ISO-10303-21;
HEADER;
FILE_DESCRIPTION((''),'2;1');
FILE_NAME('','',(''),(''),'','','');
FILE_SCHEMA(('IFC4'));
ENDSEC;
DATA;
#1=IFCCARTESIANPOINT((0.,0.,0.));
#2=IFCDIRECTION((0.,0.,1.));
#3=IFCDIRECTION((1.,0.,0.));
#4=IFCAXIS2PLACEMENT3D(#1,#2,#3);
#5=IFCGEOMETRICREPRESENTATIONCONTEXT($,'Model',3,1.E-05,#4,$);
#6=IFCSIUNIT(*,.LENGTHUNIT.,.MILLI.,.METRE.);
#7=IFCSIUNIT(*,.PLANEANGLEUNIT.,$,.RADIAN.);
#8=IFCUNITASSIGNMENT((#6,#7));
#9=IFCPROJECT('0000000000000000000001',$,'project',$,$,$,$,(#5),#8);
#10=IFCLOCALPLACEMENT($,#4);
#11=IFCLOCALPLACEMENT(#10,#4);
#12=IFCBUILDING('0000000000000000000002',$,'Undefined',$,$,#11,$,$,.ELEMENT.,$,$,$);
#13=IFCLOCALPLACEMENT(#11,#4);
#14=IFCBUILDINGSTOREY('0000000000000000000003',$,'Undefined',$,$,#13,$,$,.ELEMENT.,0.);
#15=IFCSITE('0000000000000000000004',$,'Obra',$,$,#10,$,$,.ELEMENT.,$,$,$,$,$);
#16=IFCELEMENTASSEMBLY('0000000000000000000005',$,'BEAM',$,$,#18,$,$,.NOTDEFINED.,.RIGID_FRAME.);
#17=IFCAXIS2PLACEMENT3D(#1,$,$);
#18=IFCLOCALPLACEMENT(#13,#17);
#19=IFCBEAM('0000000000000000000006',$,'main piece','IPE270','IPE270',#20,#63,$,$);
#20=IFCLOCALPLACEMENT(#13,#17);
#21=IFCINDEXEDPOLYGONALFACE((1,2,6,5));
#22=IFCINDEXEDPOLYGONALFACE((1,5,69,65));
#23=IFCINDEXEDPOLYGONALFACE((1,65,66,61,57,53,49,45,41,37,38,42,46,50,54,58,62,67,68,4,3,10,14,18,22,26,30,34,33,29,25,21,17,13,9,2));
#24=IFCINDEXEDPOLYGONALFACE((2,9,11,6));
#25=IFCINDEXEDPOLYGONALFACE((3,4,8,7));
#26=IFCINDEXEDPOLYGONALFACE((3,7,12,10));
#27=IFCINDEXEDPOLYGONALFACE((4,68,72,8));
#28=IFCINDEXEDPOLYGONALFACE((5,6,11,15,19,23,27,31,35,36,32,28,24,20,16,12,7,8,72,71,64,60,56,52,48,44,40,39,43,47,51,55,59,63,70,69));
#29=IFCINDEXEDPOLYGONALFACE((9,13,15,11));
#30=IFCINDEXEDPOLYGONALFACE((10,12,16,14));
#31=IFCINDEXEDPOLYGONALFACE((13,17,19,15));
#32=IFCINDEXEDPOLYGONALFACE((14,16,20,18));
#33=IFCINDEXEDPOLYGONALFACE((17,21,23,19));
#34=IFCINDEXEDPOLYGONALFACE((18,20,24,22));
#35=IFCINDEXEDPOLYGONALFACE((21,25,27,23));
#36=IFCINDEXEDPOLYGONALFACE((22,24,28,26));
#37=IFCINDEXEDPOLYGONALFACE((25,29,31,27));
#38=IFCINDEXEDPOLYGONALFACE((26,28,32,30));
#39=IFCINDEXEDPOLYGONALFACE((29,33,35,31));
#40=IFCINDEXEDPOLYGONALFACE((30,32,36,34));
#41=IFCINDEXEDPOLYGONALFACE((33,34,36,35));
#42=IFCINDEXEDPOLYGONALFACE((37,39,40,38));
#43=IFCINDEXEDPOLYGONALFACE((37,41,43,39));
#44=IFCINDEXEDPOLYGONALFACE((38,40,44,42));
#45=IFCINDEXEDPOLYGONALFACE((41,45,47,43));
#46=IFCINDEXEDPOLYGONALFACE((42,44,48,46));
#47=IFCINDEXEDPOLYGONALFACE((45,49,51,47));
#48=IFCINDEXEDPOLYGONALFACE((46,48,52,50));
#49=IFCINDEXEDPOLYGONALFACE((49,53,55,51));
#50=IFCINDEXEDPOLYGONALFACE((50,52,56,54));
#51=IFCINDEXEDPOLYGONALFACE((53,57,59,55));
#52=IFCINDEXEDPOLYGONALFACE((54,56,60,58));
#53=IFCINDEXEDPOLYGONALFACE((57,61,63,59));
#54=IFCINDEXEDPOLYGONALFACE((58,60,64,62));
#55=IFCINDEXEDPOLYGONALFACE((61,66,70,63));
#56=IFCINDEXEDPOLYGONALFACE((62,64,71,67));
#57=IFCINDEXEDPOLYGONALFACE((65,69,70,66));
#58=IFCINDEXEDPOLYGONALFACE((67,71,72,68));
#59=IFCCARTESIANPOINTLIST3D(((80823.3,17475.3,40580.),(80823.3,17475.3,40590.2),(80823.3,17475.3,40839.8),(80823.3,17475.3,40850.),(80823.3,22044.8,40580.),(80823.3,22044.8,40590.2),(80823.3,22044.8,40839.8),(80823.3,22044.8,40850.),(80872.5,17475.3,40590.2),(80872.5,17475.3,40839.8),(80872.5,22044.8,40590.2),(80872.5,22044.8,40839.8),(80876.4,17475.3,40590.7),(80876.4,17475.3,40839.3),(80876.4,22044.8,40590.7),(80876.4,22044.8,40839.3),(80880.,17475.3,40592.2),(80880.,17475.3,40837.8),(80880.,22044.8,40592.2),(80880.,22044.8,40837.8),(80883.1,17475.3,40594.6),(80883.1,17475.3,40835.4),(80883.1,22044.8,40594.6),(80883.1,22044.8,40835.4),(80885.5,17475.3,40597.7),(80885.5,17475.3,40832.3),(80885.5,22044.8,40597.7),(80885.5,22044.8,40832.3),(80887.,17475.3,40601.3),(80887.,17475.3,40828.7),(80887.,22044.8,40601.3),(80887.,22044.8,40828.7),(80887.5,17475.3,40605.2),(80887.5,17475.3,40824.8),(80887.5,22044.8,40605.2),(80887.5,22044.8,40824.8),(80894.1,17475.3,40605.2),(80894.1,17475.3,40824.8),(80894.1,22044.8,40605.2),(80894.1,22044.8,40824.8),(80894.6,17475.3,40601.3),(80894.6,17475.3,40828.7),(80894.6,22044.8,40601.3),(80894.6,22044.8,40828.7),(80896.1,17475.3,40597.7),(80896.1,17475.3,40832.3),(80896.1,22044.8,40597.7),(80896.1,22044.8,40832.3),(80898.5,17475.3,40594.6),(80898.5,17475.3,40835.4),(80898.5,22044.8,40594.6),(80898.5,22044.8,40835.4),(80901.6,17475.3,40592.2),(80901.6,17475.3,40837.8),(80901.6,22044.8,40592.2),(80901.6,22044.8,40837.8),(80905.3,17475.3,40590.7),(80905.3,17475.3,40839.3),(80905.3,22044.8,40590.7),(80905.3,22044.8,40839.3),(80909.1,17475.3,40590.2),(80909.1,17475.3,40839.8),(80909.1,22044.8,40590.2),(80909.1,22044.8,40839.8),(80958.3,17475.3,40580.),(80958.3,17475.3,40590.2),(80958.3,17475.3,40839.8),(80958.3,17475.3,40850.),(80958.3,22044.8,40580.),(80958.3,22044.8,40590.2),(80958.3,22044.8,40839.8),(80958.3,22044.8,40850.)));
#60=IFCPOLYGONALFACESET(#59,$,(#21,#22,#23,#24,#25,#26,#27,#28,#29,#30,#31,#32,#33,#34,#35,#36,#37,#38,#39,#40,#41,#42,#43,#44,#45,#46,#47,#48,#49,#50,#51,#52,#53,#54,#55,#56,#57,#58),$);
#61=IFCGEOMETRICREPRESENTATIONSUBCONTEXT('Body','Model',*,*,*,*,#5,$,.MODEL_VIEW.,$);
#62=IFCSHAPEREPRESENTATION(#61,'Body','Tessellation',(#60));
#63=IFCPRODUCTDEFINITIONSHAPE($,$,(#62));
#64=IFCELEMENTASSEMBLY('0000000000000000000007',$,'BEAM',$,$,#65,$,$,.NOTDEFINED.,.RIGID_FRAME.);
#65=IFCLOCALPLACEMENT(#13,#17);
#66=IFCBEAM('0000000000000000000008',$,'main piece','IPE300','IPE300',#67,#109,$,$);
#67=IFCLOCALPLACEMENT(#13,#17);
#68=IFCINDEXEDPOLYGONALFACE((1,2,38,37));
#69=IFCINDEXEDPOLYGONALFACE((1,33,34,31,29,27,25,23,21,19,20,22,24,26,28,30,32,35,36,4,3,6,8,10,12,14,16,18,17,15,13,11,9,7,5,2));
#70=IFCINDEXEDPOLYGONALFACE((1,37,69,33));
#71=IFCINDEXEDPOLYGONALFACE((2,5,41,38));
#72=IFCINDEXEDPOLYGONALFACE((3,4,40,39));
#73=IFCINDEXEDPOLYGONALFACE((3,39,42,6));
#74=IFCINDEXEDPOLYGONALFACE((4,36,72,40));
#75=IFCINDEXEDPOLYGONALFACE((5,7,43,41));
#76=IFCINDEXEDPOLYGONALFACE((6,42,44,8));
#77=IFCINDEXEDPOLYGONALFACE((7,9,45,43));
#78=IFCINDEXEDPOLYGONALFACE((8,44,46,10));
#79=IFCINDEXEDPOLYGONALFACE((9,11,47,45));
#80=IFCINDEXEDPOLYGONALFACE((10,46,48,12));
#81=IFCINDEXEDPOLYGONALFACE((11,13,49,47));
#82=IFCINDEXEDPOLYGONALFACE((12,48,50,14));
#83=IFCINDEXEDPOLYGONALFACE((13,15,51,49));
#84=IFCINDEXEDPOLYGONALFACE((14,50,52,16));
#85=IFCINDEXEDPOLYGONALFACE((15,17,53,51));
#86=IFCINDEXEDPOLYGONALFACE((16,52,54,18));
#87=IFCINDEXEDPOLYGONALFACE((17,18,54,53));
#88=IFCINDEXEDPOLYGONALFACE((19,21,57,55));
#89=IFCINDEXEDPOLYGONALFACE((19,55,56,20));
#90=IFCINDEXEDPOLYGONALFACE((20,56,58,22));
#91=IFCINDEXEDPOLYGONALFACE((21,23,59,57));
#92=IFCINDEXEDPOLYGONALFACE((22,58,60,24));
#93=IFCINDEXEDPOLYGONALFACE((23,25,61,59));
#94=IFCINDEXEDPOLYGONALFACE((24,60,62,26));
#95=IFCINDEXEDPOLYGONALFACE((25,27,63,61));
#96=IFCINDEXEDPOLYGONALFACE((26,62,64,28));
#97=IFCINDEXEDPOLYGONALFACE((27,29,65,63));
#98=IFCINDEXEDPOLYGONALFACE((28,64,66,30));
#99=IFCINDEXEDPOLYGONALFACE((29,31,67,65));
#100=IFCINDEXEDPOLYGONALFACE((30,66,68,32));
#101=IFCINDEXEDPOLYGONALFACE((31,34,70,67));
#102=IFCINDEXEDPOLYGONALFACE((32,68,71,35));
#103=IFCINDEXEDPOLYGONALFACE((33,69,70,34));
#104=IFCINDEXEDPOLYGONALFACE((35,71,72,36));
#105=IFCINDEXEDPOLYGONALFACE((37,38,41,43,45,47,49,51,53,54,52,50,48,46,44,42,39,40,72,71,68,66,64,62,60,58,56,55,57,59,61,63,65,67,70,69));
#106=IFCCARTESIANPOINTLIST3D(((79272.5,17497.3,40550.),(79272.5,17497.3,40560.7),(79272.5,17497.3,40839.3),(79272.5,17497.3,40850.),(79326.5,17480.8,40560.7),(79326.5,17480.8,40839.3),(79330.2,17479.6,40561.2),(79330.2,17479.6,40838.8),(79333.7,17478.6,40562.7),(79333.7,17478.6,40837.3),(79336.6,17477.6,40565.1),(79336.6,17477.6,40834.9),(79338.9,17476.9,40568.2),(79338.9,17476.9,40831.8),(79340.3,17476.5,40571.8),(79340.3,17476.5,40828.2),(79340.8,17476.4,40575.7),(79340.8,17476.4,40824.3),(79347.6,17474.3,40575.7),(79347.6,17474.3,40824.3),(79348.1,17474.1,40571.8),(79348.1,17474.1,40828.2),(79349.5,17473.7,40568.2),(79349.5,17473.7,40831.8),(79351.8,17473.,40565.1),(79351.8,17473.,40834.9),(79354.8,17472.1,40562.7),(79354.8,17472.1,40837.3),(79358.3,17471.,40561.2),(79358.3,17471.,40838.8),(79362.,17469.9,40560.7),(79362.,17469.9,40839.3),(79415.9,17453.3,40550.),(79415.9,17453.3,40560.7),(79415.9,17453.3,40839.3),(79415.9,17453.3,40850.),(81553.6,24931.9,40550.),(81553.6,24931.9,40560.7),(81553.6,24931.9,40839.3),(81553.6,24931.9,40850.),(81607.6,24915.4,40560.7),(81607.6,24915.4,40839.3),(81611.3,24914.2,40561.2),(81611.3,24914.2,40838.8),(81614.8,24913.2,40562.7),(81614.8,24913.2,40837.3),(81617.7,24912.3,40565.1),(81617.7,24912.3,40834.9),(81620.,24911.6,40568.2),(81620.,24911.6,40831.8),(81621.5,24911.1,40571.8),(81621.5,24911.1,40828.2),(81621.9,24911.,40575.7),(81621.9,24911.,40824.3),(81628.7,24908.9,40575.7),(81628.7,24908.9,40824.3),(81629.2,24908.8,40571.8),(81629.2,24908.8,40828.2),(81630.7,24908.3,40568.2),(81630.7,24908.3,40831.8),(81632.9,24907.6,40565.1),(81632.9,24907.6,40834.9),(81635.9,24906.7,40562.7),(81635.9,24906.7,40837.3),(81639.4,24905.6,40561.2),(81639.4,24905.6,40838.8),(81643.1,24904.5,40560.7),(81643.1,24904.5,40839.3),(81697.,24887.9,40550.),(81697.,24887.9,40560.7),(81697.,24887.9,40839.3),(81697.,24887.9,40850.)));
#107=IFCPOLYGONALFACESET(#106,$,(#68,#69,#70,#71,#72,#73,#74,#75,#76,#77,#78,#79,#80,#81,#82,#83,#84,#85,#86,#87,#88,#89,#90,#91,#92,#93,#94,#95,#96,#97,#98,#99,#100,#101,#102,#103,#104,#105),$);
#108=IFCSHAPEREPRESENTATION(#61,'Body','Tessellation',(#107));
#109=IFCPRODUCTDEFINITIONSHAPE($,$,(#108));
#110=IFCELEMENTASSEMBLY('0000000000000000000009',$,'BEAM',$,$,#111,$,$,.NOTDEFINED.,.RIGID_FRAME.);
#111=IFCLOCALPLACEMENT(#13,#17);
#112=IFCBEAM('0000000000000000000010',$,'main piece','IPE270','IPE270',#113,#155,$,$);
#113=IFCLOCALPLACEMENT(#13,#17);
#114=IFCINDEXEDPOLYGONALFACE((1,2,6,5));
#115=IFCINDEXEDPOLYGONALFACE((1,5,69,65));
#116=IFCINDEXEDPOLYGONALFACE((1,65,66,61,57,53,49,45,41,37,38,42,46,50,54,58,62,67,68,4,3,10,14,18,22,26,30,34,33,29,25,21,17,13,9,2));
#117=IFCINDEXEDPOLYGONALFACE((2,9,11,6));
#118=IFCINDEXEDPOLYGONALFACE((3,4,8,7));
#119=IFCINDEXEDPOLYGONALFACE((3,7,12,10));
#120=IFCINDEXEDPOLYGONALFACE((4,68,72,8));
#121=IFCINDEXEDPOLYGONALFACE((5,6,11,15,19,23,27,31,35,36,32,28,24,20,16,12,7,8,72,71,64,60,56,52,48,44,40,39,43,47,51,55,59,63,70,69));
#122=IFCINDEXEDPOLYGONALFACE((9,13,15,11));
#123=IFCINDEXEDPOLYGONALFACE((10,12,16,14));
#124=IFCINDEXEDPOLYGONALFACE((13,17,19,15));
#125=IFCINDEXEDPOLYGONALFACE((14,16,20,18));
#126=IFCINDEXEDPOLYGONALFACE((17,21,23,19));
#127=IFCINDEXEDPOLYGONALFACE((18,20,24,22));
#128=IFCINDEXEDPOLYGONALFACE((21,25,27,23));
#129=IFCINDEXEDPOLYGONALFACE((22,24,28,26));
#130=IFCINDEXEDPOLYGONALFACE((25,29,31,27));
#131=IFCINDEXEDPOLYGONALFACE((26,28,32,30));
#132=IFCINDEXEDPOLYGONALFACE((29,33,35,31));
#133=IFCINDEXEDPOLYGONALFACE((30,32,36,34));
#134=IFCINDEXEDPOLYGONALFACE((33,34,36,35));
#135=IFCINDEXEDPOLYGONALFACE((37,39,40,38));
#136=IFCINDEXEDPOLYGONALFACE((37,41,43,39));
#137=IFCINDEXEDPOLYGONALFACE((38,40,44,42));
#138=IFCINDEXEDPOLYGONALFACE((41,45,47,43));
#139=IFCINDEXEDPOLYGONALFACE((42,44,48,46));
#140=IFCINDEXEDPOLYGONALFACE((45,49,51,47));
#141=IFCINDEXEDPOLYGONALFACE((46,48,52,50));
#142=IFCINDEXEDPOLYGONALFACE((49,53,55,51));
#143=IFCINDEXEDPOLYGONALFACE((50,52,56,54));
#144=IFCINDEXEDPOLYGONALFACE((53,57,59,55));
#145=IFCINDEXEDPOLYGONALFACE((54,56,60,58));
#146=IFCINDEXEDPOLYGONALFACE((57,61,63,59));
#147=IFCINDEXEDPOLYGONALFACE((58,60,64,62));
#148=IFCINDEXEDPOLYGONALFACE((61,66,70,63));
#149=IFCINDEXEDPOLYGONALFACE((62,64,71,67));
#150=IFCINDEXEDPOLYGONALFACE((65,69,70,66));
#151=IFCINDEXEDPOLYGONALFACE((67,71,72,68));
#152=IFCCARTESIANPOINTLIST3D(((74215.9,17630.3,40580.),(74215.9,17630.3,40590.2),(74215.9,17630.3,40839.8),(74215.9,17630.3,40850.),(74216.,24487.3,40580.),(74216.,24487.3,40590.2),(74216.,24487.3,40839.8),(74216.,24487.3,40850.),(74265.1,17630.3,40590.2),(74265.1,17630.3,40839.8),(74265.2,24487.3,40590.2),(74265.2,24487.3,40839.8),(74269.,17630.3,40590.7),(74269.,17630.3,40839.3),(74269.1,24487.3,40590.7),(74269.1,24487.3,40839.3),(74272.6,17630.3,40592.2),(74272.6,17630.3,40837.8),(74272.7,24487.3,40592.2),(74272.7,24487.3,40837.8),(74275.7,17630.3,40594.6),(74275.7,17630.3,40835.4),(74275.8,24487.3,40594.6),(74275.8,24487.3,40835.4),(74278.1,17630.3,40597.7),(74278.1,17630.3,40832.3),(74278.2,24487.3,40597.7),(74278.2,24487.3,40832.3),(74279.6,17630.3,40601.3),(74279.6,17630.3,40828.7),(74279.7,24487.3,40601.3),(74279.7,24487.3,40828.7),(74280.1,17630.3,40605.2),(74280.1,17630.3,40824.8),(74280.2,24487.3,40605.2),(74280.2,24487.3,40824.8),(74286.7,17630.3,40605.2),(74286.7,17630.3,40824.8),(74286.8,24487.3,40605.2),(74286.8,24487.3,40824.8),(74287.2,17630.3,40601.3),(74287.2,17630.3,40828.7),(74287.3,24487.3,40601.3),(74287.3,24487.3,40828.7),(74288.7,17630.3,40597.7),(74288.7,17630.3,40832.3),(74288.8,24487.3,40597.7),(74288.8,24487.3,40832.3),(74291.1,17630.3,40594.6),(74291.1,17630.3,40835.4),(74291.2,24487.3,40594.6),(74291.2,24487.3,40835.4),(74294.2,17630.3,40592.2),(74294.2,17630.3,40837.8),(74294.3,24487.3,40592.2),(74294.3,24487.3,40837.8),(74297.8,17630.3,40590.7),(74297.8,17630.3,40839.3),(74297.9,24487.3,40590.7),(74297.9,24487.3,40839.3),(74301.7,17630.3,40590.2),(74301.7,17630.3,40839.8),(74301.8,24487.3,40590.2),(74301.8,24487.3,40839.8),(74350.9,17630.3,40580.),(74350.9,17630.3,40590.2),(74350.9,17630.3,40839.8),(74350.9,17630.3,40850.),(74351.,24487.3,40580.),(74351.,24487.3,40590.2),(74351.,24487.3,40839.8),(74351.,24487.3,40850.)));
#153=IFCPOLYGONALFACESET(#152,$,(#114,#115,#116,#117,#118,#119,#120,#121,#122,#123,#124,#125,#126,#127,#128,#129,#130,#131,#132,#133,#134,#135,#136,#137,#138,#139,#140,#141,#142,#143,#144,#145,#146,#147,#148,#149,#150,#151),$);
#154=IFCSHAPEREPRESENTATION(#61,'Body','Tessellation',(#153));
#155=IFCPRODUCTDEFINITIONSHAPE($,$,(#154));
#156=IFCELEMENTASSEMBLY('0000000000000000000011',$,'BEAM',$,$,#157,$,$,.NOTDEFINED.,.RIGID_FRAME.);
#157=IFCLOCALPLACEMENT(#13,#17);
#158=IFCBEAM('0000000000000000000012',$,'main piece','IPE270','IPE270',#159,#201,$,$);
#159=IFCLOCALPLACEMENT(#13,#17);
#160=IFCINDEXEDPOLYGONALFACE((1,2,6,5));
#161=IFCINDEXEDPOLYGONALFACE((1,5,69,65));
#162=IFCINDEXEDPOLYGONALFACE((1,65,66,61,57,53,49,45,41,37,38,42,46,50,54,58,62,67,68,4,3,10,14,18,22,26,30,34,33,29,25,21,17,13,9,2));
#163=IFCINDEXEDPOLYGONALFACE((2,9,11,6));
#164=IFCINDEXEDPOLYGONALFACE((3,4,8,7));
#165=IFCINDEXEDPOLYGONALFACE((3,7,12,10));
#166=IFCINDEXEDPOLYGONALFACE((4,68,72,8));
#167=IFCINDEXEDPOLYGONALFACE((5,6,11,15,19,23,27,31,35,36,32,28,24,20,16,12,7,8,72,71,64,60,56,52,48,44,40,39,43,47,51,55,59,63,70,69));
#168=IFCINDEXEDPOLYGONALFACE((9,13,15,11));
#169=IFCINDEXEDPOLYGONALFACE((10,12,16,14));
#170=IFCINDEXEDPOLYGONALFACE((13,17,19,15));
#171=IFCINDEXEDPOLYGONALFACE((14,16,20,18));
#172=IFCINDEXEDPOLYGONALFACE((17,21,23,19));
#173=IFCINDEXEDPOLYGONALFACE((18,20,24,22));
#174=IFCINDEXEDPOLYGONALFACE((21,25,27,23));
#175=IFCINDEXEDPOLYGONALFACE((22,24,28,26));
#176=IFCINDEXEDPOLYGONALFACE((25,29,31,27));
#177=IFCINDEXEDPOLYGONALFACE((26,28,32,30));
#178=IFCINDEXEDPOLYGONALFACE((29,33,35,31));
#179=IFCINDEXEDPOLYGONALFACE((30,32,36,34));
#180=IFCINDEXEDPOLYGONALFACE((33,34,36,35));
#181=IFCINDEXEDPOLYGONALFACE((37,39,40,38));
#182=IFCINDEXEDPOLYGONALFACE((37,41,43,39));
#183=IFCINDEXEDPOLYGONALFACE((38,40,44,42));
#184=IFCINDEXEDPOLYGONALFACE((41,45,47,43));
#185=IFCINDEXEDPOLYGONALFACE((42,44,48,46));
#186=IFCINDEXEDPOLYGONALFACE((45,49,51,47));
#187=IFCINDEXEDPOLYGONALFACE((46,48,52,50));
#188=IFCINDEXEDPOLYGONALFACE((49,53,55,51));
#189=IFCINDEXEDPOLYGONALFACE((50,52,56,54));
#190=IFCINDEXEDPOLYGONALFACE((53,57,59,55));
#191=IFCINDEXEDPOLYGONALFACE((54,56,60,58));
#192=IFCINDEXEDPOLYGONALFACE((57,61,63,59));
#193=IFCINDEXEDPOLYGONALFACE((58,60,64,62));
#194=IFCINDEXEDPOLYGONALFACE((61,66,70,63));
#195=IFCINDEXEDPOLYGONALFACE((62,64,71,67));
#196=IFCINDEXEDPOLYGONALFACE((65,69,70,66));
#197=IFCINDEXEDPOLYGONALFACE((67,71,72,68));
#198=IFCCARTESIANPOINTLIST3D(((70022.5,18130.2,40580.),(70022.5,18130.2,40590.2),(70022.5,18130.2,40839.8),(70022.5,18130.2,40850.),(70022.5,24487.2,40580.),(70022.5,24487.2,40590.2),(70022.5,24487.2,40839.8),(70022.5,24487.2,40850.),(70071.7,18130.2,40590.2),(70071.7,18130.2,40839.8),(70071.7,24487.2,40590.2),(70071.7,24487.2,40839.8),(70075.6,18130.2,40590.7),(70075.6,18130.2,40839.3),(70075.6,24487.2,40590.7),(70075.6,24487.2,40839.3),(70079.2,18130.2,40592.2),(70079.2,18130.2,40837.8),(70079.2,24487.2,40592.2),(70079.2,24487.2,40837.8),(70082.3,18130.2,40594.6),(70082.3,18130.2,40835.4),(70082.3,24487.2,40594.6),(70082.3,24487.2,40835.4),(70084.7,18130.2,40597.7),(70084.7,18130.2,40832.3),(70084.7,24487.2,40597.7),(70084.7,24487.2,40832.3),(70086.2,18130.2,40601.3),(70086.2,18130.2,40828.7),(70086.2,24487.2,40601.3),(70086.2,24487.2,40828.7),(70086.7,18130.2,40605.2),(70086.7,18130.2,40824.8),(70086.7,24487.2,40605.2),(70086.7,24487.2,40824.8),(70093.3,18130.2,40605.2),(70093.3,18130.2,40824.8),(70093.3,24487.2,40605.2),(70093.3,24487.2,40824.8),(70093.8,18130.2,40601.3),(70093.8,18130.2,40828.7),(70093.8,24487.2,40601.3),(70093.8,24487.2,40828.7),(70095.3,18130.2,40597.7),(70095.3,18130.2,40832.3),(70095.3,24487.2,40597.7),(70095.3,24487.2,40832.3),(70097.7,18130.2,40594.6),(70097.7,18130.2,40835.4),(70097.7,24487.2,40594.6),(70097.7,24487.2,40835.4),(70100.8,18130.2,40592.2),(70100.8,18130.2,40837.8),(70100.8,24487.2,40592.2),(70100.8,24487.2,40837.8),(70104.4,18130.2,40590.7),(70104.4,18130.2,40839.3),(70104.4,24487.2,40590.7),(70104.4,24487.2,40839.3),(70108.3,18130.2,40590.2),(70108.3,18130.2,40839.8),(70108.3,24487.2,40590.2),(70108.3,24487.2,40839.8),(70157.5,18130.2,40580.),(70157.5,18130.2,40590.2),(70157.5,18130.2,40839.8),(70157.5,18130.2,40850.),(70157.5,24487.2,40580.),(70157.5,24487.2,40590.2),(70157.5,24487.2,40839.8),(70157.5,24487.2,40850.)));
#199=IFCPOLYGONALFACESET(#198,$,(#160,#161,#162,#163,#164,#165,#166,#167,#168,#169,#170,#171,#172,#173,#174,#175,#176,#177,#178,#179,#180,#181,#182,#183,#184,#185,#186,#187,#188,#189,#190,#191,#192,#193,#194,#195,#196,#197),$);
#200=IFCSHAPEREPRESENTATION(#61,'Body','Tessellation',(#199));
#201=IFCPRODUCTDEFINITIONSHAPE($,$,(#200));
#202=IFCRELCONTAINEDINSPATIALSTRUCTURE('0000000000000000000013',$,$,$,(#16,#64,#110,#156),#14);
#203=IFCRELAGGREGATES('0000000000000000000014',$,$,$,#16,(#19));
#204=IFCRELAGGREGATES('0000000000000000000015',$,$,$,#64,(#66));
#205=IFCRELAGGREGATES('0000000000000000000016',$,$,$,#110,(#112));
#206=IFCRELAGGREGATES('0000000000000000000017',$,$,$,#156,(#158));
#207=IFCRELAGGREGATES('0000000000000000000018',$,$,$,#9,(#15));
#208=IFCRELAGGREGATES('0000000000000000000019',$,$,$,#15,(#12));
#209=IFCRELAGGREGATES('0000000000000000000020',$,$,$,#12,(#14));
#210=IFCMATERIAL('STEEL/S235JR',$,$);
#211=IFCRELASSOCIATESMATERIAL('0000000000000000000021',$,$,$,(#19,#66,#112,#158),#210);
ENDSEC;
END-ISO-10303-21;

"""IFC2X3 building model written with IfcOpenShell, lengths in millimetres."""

from ifc_helpers import new_model, si_unit, frame, origin_with_axes, origin_2d_with_axis, place, context, subcontext, project, spatial, i_section, extrude, material, element, aggregate, save


model = new_model("IFC2X3")

# Units and contexts
model_context = context("Model", 3, precision=1e-05, world=origin_with_axes())
body_context = subcontext(model_context, "Body", "Model", "MODEL_VIEW")
ifc_project = project(units=[si_unit("LENGTHUNIT", "METRE", prefix="MILLI"), si_unit("PLANEANGLEUNIT", "RADIAN")], contexts=[model_context])

# Site, building, storey
site_placement = place(None, origin_with_axes())
site = spatial("IfcSite", under=ifc_project, at=site_placement, Name="Obra", CompositionType="ELEMENT")
building_placement = place(site_placement, origin_with_axes())
building = spatial("IfcBuilding", under=site, at=building_placement, Name="Undefined", CompositionType="ELEMENT")
storey_placement = place(building_placement, origin_with_axes())
storey = spatial("IfcBuildingStorey", under=building, at=storey_placement, Name="Undefined", CompositionType="ELEMENT", Elevation=0.0)

# Element assemblies, beams
ifc_material_1 = material(Name="STEEL/S235JR")
assembly_1_placement = place(storey_placement, origin_with_axes())
assembly_1 = element("IfcElementAssembly", 1, at=assembly_1_placement, inside=storey, Name="BEAM", AssemblyPlace="NOTDEFINED", PredefinedType="RIGID_FRAME")
beam_1_placement = place(assembly_1_placement, frame((80890.8, 17475.3, 40715.0), z_axis=(0.0, 0.0, 1.0), x_axis=(0.0, 1.0, 0.0)))
beam_1 = element("IfcBeam", 2, at=beam_1_placement, material=ifc_material_1, Name="main piece", Description="IPE270", ObjectType="IPE270", context=body_context, shape_type="SweptSolid", body=[
    extrude(i_section(OverallWidth=135.0, OverallDepth=270.0, WebThickness=6.6, FlangeThickness=10.2, FilletRadius=15.0, at=origin_2d_with_axis()), frame((4569.5, 0.0, 0.0), z_axis=(-1.0, 0.0, 0.0), x_axis=(0.0, -1.0, 0.0)), (0.0, 0.0, 1.0), 4569.5),
])
aggregate(assembly_1, [beam_1])
assembly_2_placement = place(storey_placement, origin_with_axes())
assembly_2 = element("IfcElementAssembly", 3, at=assembly_2_placement, inside=storey, Name="BEAM", AssemblyPlace="NOTDEFINED", PredefinedType="RIGID_FRAME")
beam_2_placement = place(assembly_2_placement, frame((79344.2, 17475.3, 40700.0), z_axis=(0.0, 0.0, 1.0), x_axis=(0.293326, 0.956013, 0.0)))
beam_2 = element("IfcBeam", 4, at=beam_2_placement, material=ifc_material_1, Name="main piece", Description="IPE300", ObjectType="IPE300", context=body_context, shape_type="SweptSolid", body=[
    extrude(i_section(OverallWidth=150.0, OverallDepth=300.0, WebThickness=7.1, FlangeThickness=10.7, FilletRadius=15.0, at=origin_2d_with_axis()), frame((7776.7, 0.0, 0.0), z_axis=(-1.0, 0.0, 0.0), x_axis=(0.0, -1.0, 0.0)), (0.0, 0.0, 1.0), 7776.7),
])
aggregate(assembly_2, [beam_2])
assembly_3_placement = place(storey_placement, origin_with_axes())
assembly_3 = element("IfcElementAssembly", 5, at=assembly_3_placement, inside=storey, Name="BEAM", AssemblyPlace="NOTDEFINED", PredefinedType="RIGID_FRAME")
beam_3_placement = place(assembly_3_placement, frame((74283.4, 17630.3, 40715.0), z_axis=(0.0, 0.0, 1.0), x_axis=(0.000014, 1.0, 0.0)))
beam_3 = element("IfcBeam", 6, at=beam_3_placement, material=ifc_material_1, Name="main piece", Description="IPE270", ObjectType="IPE270", context=body_context, shape_type="SweptSolid", body=[
    extrude(i_section(OverallWidth=135.0, OverallDepth=270.0, WebThickness=6.6, FlangeThickness=10.2, FilletRadius=15.0, at=origin_2d_with_axis()), frame((6857.0, 0.0, 0.0), z_axis=(-1.0, 0.0, 0.0), x_axis=(0.0, -1.0, 0.0)), (0.0, 0.0, 1.0), 6857.0),
])
aggregate(assembly_3, [beam_3])
assembly_4_placement = place(storey_placement, origin_with_axes())
assembly_4 = element("IfcElementAssembly", 7, at=assembly_4_placement, inside=storey, Name="BEAM", AssemblyPlace="NOTDEFINED", PredefinedType="RIGID_FRAME")
beam_4_placement = place(assembly_4_placement, frame((70090.0, 18130.2, 40715.0), z_axis=(0.0, 0.0, 1.0), x_axis=(0.0, 1.0, 0.0)))
beam_4 = element("IfcBeam", 8, at=beam_4_placement, material=ifc_material_1, Name="main piece", Description="IPE270", ObjectType="IPE270", context=body_context, shape_type="SweptSolid", body=[
    extrude(i_section(OverallWidth=135.0, OverallDepth=270.0, WebThickness=6.6, FlangeThickness=10.2, FilletRadius=15.0, at=origin_2d_with_axis()), frame((6357.0, 0.0, 0.0), z_axis=(-1.0, 0.0, 0.0), x_axis=(0.0, -1.0, 0.0)), (0.0, 0.0, 1.0), 6357.0),
])
aggregate(assembly_4, [beam_4])

save(model, "model.ifc")
